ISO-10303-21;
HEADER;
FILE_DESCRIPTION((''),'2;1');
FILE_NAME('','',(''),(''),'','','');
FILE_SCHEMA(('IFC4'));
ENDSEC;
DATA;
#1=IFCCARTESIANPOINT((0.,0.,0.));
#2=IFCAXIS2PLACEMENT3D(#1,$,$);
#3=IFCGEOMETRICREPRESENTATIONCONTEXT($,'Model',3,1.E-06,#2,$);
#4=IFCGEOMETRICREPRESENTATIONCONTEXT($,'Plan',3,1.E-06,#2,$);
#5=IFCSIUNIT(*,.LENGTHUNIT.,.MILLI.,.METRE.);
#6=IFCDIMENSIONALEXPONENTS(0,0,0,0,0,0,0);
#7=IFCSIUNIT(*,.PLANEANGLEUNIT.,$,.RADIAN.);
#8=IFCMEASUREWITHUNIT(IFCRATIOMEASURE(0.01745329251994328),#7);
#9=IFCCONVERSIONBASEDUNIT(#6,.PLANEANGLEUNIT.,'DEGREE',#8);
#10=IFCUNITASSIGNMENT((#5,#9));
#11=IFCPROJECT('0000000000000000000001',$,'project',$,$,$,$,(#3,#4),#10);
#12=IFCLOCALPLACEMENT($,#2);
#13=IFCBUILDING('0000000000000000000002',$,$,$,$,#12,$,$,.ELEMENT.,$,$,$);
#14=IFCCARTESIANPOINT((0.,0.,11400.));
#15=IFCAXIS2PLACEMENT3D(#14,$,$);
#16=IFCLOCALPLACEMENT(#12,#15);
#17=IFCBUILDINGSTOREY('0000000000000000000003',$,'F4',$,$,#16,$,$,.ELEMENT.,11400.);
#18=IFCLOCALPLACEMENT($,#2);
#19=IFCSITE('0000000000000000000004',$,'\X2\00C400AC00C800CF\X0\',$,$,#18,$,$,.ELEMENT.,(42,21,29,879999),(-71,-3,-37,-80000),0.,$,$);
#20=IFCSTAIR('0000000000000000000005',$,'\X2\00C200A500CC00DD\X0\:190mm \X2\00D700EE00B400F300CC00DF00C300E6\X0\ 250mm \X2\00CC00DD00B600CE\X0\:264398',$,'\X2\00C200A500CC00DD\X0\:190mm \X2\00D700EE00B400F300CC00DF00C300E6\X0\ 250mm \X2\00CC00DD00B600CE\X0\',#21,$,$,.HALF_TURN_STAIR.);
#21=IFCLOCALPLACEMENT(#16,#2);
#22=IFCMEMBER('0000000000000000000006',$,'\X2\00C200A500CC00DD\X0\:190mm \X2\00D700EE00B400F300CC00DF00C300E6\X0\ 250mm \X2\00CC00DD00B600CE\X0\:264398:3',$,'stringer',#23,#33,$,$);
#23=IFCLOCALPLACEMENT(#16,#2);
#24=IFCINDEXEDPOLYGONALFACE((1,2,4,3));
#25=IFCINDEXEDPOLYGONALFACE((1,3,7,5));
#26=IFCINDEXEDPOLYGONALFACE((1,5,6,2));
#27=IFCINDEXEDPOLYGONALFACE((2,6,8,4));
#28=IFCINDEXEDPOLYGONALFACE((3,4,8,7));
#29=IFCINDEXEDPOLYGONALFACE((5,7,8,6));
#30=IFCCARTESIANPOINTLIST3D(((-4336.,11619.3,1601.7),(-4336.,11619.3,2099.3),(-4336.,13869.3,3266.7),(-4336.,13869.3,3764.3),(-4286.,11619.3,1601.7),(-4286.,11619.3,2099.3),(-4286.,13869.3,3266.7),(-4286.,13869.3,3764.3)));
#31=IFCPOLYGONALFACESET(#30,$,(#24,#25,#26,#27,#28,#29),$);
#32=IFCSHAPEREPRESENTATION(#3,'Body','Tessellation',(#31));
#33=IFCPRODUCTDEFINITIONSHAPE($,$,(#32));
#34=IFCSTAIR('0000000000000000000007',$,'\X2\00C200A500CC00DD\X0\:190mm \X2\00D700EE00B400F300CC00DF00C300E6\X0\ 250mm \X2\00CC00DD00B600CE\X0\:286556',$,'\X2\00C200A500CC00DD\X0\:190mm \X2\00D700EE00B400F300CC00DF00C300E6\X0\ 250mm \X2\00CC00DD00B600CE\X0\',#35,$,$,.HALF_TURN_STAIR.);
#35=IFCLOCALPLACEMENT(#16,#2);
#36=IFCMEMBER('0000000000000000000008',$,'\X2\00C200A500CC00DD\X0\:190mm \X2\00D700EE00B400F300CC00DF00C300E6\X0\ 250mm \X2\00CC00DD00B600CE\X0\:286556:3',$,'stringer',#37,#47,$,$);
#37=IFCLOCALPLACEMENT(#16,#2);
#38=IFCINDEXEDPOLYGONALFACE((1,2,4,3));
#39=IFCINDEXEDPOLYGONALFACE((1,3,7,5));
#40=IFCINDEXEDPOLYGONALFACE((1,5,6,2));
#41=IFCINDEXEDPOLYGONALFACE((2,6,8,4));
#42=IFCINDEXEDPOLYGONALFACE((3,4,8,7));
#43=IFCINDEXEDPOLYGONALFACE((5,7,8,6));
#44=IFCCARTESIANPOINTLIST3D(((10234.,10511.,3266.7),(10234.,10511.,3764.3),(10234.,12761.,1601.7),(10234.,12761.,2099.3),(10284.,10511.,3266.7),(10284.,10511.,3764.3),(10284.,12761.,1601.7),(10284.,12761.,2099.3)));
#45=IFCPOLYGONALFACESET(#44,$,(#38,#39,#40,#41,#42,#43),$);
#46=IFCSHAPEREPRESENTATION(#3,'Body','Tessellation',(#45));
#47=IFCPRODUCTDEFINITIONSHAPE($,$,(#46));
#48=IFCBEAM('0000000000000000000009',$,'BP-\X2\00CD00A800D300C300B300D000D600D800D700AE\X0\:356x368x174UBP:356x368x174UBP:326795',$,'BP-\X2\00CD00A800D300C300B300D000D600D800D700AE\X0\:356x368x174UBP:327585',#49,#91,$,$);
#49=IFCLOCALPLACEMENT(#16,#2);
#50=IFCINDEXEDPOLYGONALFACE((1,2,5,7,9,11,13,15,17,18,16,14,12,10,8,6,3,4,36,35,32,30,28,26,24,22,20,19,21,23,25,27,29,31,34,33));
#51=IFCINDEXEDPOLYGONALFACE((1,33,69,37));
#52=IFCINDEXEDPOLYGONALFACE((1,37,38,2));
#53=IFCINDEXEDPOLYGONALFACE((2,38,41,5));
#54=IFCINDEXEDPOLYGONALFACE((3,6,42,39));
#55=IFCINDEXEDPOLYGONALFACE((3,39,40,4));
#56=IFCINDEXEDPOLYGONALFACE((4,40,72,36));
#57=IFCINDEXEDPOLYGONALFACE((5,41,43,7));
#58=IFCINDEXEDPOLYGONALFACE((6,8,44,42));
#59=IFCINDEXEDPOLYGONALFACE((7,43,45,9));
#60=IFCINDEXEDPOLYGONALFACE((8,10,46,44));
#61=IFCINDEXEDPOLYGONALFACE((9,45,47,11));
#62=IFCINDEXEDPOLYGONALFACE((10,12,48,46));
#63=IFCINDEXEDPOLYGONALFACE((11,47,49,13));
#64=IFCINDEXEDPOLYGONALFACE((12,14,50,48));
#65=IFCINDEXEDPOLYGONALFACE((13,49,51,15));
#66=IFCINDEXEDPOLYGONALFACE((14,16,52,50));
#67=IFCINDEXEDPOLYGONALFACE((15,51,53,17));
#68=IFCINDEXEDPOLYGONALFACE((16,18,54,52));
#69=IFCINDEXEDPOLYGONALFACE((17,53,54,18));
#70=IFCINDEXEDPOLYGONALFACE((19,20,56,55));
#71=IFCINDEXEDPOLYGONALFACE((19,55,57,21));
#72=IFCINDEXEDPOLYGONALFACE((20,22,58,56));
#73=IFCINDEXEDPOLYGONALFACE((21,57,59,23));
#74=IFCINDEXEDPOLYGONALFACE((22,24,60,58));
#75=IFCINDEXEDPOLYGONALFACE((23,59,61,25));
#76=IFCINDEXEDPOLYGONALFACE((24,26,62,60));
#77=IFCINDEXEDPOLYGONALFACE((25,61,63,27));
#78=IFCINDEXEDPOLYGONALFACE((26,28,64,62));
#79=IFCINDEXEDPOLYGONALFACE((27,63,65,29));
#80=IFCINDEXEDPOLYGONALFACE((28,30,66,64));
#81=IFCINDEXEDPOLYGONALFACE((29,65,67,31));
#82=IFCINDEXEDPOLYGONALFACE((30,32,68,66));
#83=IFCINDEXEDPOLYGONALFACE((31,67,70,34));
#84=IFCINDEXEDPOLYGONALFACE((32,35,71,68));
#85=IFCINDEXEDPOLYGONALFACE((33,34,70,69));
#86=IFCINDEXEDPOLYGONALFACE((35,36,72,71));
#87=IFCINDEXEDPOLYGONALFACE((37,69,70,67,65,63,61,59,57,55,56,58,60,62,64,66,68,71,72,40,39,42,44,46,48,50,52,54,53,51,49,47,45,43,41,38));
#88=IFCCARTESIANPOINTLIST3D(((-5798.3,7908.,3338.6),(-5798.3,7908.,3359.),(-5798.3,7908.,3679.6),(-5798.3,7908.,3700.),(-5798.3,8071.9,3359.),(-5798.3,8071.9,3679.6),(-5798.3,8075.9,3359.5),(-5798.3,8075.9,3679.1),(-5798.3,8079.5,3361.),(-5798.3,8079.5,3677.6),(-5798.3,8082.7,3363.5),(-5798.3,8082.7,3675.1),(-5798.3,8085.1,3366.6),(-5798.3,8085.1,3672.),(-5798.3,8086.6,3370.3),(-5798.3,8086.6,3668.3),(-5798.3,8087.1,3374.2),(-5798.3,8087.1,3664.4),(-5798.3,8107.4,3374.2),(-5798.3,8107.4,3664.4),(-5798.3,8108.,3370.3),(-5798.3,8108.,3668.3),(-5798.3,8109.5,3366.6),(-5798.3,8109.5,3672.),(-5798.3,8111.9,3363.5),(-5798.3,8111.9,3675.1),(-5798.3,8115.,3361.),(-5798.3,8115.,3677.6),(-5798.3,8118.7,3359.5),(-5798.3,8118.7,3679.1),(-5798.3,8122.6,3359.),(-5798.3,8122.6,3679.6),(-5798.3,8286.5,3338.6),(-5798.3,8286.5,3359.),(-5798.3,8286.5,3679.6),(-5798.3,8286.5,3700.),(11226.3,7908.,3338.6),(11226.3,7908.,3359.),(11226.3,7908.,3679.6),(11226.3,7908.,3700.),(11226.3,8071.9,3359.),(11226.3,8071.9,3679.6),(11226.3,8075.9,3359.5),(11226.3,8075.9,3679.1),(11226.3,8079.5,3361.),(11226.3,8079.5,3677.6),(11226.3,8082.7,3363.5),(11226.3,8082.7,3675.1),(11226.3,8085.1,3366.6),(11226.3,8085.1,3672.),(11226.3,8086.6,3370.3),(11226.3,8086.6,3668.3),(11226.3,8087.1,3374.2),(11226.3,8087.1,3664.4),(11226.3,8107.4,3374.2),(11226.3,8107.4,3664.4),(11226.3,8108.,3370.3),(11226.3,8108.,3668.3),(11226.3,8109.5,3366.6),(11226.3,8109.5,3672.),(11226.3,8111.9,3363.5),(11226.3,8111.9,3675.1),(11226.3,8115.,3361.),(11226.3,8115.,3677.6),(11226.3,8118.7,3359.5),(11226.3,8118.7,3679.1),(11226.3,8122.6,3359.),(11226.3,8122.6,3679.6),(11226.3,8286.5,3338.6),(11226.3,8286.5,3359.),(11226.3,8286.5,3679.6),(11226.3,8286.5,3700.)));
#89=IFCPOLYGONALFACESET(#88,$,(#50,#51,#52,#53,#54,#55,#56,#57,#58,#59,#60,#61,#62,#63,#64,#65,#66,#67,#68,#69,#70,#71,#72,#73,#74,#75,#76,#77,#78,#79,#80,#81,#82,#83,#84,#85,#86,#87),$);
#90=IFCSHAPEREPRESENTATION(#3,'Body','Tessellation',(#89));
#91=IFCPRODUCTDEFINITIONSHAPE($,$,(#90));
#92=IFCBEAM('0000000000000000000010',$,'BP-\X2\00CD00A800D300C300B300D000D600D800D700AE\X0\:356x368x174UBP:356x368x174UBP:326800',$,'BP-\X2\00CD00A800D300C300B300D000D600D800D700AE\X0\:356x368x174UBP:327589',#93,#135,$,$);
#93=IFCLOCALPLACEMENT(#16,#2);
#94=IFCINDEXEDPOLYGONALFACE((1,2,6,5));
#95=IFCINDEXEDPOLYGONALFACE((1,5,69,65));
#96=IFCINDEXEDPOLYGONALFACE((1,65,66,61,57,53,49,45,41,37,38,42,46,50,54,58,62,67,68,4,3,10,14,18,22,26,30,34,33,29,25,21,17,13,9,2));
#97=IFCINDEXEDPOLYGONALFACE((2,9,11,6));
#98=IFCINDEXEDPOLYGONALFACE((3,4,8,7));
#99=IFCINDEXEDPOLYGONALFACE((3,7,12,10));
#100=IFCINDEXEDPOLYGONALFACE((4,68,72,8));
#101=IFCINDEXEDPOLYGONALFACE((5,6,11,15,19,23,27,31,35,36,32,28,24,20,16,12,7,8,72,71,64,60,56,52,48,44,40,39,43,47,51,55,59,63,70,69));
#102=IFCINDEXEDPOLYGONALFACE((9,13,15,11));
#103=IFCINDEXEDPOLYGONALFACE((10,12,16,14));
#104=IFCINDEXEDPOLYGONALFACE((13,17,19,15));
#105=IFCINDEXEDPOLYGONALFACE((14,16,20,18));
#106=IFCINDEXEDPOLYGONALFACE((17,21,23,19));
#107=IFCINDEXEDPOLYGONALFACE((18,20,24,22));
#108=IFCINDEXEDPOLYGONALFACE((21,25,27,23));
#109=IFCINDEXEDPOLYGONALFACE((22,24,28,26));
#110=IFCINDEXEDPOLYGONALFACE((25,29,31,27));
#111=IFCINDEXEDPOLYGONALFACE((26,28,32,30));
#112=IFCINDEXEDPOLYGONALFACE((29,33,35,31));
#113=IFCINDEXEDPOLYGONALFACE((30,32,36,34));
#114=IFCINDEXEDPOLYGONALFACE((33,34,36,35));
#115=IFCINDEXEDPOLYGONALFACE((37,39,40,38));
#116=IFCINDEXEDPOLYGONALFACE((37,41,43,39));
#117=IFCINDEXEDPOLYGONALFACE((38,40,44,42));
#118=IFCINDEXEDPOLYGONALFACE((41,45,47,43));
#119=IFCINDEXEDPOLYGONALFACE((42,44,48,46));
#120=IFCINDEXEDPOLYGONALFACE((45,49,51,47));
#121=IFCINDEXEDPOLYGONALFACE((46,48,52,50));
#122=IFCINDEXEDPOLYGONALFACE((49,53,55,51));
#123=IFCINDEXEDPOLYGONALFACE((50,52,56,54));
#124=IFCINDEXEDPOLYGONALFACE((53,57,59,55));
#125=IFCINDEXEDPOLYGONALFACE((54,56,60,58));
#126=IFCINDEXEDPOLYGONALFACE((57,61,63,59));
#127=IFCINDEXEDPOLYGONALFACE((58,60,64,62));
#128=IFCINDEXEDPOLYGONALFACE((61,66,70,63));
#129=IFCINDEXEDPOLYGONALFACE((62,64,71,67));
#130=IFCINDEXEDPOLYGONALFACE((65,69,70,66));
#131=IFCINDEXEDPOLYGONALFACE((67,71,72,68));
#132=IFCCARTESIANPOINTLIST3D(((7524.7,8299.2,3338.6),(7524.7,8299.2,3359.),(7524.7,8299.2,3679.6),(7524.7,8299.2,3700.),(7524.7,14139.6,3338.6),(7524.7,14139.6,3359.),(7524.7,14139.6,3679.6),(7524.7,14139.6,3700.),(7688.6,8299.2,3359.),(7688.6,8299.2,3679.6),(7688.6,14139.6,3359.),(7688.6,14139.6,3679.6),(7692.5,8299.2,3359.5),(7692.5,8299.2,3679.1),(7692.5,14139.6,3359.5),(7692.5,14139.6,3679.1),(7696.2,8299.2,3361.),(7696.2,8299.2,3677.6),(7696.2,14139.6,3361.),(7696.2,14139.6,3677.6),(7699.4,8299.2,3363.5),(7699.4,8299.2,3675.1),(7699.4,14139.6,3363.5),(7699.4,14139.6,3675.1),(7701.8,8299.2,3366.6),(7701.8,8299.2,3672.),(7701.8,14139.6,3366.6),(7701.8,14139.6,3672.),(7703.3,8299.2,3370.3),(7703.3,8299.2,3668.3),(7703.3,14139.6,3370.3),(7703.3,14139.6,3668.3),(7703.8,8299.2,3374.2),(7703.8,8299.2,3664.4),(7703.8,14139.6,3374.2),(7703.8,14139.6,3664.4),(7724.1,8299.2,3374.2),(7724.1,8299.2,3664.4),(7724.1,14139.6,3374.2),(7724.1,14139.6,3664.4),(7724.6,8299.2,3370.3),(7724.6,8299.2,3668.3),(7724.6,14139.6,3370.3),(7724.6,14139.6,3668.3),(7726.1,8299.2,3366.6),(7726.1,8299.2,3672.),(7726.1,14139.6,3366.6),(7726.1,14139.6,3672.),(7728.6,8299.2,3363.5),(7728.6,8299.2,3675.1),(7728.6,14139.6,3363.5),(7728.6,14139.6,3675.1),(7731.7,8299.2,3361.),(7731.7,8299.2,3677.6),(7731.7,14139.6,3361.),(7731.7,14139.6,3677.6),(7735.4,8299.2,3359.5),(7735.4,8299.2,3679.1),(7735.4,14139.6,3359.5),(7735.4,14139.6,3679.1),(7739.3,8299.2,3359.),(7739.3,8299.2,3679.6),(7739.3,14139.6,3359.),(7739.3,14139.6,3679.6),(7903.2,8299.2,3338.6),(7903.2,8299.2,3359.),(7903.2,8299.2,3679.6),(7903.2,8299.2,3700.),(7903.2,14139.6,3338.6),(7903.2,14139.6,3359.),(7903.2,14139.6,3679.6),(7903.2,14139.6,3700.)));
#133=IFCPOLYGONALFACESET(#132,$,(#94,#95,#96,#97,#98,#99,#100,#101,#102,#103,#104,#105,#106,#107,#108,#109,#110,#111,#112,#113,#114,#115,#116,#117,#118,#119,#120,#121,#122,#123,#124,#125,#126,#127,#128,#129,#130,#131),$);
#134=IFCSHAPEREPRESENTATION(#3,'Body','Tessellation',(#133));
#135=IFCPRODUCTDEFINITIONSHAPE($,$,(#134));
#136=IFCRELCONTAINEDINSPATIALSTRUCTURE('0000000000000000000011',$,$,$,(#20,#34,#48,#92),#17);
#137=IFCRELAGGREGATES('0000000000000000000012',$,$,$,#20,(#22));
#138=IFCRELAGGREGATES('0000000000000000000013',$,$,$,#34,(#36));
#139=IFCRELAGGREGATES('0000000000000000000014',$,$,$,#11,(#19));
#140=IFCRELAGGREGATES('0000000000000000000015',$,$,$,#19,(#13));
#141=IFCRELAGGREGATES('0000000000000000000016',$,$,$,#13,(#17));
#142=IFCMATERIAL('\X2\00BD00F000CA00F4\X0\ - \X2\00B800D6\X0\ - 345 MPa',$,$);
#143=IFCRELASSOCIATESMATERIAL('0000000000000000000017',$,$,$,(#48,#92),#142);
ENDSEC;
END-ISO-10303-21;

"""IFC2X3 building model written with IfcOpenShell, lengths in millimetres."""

from ifc_helpers import new_model, entity, si_unit, converted_unit, frame, frame_2d, origin, origin_2d_with_axis, place, context, project, spatial, polyline, circle_curve, parameter, trimmed, segment, composite_curve, rectangle, outline, extrude, material, element, aggregate, save


model = new_model("IFC2X3")

# Units and contexts
model_context = context("Model", 3, precision=1e-06, world=origin())
plan_context = context("Plan", 3, precision=1e-06, world=origin())
ifc_project = project(units=[si_unit("LENGTHUNIT", "METRE", prefix="MILLI"), converted_unit("PLANEANGLEUNIT", "DEGREE", entity("IfcRatioMeasure", 0.01745329251994328), si_unit("PLANEANGLEUNIT", "RADIAN"), dimensions=[0, 0, 0, 0, 0, 0, 0])], contexts=[model_context, plan_context])

# Site, building, storey
site_placement = place(None, origin())
site = spatial("IfcSite", under=ifc_project, at=site_placement, Name="Ä¬ÈÏ", CompositionType="ELEMENT", RefLatitude=(42, 21, 29, 879999), RefLongitude=(-71, -3, -37, -80000), RefElevation=0.0)
building_placement = place(None, origin())
building = spatial("IfcBuilding", under=site, at=building_placement, CompositionType="ELEMENT")
storey_placement = place(building_placement, frame((0.0, 0.0, 11400.0)))
storey = spatial("IfcBuildingStorey", under=building, at=storey_placement, Name="F4", CompositionType="ELEMENT", Elevation=11400.0)

# Stairs, members
stair_1_placement = place(storey_placement, origin())
stair_1 = element("IfcStair", 1, at=stair_1_placement, inside=storey, Name="Â¥ÌÝ:190mm ×î´óÌßÃæ 250mm ÌÝ¶Î:264398", ObjectType="Â¥ÌÝ:190mm ×î´óÌßÃæ 250mm ÌÝ¶Î", ShapeType="HALF_TURN_STAIR")
member_1_placement = place(storey_placement, origin())
member_1 = element("IfcMember", 2, at=member_1_placement, Name="Â¥ÌÝ:190mm ×î´óÌßÃæ 250mm ÌÝ¶Î:264398:3", ObjectType="stringer", context=model_context, shape_type="SweptSolid", body=[
    extrude(rectangle(XDim=2799.1, YDim=50.0, at=origin_2d_with_axis()), frame((-4311.0, 12744.3, 2434.2), z_axis=(0.0, -0.594843, 0.803842), x_axis=(0.0, 0.803842, 0.594843)), (0.594843, 0.0, 0.803842), 497.6),
])
stair_2_placement = place(storey_placement, origin())
stair_2 = element("IfcStair", 3, at=stair_2_placement, inside=storey, Name="Â¥ÌÝ:190mm ×î´óÌßÃæ 250mm ÌÝ¶Î:286556", ObjectType="Â¥ÌÝ:190mm ×î´óÌßÃæ 250mm ÌÝ¶Î", ShapeType="HALF_TURN_STAIR")
member_2_placement = place(storey_placement, origin())
member_2 = element("IfcMember", 4, at=member_2_placement, Name="Â¥ÌÝ:190mm ×î´óÌßÃæ 250mm ÌÝ¶Î:286556:3", ObjectType="stringer", context=model_context, shape_type="SweptSolid", body=[
    extrude(rectangle(XDim=2799.1, YDim=50.0, at=origin_2d_with_axis()), frame((10259.0, 11636.0, 2434.2), z_axis=(0.0, 0.594843, 0.803842), x_axis=(0.0, -0.803842, 0.594843)), (0.594843, 0.0, 0.803842), 497.6),
])

# Beams
ifc_material_1 = material(Name="½ðÊô - ¸Ö - 345 MPa")
beam_1_placement = place(storey_placement, frame((11464.0, 8097.3, 3700.0), z_axis=(0.0, 0.0, 1.0), x_axis=(0.0, 1.0, 0.0)))
element("IfcBeam", 5, at=beam_1_placement, inside=storey, material=ifc_material_1, Name="BP-Í¨ÓÃ³ÐÖØ×®:356x368x174UBP:356x368x174UBP:326795", ObjectType="BP-Í¨ÓÃ³ÐÖØ×®:356x368x174UBP:327585", context=model_context, shape_type="SweptSolid", body=[
    extrude(outline(composite_curve([segment(polyline([(160.3, -189.3), (180.7, -189.3)]), True, "CONTINUOUS"), segment(polyline([(180.7, -189.3), (180.7, 189.2)]), True, "CONTINUOUS"), segment(polyline([(180.7, 189.2), (160.3, 189.2)]), True, "CONTINUOUS"), segment(polyline([(160.3, 189.2), (160.3, 25.3)]), True, "CONTINUOUS"), segment(trimmed(circle_curve(frame_2d((145.1, 25.3), x_axis=(1.0, 0.0)), 15.2), [parameter(270.0)], [parameter(0.0)], True, "PARAMETER"), False, "CONTINUOUS"), segment(polyline([(145.1, 10.1), (-145.1, 10.1)]), True, "CONTINUOUS"), segment(trimmed(circle_curve(frame_2d((-145.1, 25.3), x_axis=(0.0, -1.0)), 15.2), [parameter(270.0)], [parameter(360.0)], True, "PARAMETER"), False, "CONTINUOUS"), segment(polyline([(-160.3, 25.3), (-160.3, 189.2)]), True, "CONTINUOUS"), segment(polyline([(-160.3, 189.2), (-180.7, 189.2)]), True, "CONTINUOUS"), segment(polyline([(-180.7, 189.2), (-180.7, -189.3)]), True, "CONTINUOUS"), segment(polyline([(-180.7, -189.3), (-160.3, -189.3)]), True, "CONTINUOUS"), segment(polyline([(-160.3, -189.3), (-160.3, -25.4)]), True, "CONTINUOUS"), segment(trimmed(circle_curve(frame_2d((-145.1, -25.4), x_axis=(-1.0, 0.0)), 15.2), [parameter(270.0)], [parameter(0.0)], True, "PARAMETER"), False, "CONTINUOUS"), segment(polyline([(-145.1, -10.2), (145.1, -10.2)]), True, "CONTINUOUS"), segment(trimmed(circle_curve(frame_2d((145.1, -25.4), x_axis=(0.0, 1.0)), 15.2), [parameter(270.0)], [parameter(0.0)], True, "PARAMETER"), False, "CONTINUOUS"), segment(polyline([(160.3, -25.4), (160.3, -189.3)]), True, "CONTINUOUS")], self_intersect=False)), frame((0.0, 17262.3, -180.7), z_axis=(0.0, -1.0, 0.0), x_axis=(0.0, 0.0, -1.0)), (0.0, 0.0, 1.0), 17024.6),
])
beam_2_placement = place(storey_placement, frame((7714.0, 14377.3, 3700.0), z_axis=(0.0, 0.0, 1.0), x_axis=(-1.0, 0.0, 0.0)))
element("IfcBeam", 6, at=beam_2_placement, inside=storey, material=ifc_material_1, Name="BP-Í¨ÓÃ³ÐÖØ×®:356x368x174UBP:356x368x174UBP:326800", ObjectType="BP-Í¨ÓÃ³ÐÖØ×®:356x368x174UBP:327589", context=model_context, shape_type="SweptSolid", body=[
    extrude(outline(composite_curve([segment(polyline([(160.3, -189.3), (180.7, -189.3)]), True, "CONTINUOUS"), segment(polyline([(180.7, -189.3), (180.7, 189.2)]), True, "CONTINUOUS"), segment(polyline([(180.7, 189.2), (160.3, 189.2)]), True, "CONTINUOUS"), segment(polyline([(160.3, 189.2), (160.3, 25.3)]), True, "CONTINUOUS"), segment(trimmed(circle_curve(frame_2d((145.1, 25.3), x_axis=(0.0, 1.0)), 15.2), [parameter(180.0)], [parameter(270.0)], True, "PARAMETER"), False, "CONTINUOUS"), segment(polyline([(145.1, 10.1), (-145.1, 10.1)]), True, "CONTINUOUS"), segment(trimmed(circle_curve(frame_2d((-145.1, 25.3), x_axis=(0.0, 1.0)), 15.2), [parameter(90.0)], [parameter(180.0)], True, "PARAMETER"), False, "CONTINUOUS"), segment(polyline([(-160.3, 25.3), (-160.3, 189.2)]), True, "CONTINUOUS"), segment(polyline([(-160.3, 189.2), (-180.7, 189.2)]), True, "CONTINUOUS"), segment(polyline([(-180.7, 189.2), (-180.7, -189.3)]), True, "CONTINUOUS"), segment(polyline([(-180.7, -189.3), (-160.3, -189.3)]), True, "CONTINUOUS"), segment(polyline([(-160.3, -189.3), (-160.3, -25.4)]), True, "CONTINUOUS"), segment(trimmed(circle_curve(frame_2d((-145.1, -25.4), x_axis=(0.0, 1.0)), 15.2), [parameter(360.0)], [parameter(90.0)], True, "PARAMETER"), False, "CONTINUOUS"), segment(polyline([(-145.1, -10.2), (145.1, -10.2)]), True, "CONTINUOUS"), segment(trimmed(circle_curve(frame_2d((145.1, -25.4), x_axis=(0.0, 1.0)), 15.2), [parameter(270.0)], [parameter(360.0)], True, "PARAMETER"), False, "CONTINUOUS"), segment(polyline([(160.3, -25.4), (160.3, -189.3)]), True, "CONTINUOUS")], self_intersect=False)), frame((0.0, 6078.0, -180.7), z_axis=(0.0, -1.0, 0.0), x_axis=(0.0, 0.0, -1.0)), (0.0, 0.0, 1.0), 5840.3),
])

aggregate(stair_1, [member_1])
aggregate(stair_2, [member_2])

save(model, "model.ifc")
